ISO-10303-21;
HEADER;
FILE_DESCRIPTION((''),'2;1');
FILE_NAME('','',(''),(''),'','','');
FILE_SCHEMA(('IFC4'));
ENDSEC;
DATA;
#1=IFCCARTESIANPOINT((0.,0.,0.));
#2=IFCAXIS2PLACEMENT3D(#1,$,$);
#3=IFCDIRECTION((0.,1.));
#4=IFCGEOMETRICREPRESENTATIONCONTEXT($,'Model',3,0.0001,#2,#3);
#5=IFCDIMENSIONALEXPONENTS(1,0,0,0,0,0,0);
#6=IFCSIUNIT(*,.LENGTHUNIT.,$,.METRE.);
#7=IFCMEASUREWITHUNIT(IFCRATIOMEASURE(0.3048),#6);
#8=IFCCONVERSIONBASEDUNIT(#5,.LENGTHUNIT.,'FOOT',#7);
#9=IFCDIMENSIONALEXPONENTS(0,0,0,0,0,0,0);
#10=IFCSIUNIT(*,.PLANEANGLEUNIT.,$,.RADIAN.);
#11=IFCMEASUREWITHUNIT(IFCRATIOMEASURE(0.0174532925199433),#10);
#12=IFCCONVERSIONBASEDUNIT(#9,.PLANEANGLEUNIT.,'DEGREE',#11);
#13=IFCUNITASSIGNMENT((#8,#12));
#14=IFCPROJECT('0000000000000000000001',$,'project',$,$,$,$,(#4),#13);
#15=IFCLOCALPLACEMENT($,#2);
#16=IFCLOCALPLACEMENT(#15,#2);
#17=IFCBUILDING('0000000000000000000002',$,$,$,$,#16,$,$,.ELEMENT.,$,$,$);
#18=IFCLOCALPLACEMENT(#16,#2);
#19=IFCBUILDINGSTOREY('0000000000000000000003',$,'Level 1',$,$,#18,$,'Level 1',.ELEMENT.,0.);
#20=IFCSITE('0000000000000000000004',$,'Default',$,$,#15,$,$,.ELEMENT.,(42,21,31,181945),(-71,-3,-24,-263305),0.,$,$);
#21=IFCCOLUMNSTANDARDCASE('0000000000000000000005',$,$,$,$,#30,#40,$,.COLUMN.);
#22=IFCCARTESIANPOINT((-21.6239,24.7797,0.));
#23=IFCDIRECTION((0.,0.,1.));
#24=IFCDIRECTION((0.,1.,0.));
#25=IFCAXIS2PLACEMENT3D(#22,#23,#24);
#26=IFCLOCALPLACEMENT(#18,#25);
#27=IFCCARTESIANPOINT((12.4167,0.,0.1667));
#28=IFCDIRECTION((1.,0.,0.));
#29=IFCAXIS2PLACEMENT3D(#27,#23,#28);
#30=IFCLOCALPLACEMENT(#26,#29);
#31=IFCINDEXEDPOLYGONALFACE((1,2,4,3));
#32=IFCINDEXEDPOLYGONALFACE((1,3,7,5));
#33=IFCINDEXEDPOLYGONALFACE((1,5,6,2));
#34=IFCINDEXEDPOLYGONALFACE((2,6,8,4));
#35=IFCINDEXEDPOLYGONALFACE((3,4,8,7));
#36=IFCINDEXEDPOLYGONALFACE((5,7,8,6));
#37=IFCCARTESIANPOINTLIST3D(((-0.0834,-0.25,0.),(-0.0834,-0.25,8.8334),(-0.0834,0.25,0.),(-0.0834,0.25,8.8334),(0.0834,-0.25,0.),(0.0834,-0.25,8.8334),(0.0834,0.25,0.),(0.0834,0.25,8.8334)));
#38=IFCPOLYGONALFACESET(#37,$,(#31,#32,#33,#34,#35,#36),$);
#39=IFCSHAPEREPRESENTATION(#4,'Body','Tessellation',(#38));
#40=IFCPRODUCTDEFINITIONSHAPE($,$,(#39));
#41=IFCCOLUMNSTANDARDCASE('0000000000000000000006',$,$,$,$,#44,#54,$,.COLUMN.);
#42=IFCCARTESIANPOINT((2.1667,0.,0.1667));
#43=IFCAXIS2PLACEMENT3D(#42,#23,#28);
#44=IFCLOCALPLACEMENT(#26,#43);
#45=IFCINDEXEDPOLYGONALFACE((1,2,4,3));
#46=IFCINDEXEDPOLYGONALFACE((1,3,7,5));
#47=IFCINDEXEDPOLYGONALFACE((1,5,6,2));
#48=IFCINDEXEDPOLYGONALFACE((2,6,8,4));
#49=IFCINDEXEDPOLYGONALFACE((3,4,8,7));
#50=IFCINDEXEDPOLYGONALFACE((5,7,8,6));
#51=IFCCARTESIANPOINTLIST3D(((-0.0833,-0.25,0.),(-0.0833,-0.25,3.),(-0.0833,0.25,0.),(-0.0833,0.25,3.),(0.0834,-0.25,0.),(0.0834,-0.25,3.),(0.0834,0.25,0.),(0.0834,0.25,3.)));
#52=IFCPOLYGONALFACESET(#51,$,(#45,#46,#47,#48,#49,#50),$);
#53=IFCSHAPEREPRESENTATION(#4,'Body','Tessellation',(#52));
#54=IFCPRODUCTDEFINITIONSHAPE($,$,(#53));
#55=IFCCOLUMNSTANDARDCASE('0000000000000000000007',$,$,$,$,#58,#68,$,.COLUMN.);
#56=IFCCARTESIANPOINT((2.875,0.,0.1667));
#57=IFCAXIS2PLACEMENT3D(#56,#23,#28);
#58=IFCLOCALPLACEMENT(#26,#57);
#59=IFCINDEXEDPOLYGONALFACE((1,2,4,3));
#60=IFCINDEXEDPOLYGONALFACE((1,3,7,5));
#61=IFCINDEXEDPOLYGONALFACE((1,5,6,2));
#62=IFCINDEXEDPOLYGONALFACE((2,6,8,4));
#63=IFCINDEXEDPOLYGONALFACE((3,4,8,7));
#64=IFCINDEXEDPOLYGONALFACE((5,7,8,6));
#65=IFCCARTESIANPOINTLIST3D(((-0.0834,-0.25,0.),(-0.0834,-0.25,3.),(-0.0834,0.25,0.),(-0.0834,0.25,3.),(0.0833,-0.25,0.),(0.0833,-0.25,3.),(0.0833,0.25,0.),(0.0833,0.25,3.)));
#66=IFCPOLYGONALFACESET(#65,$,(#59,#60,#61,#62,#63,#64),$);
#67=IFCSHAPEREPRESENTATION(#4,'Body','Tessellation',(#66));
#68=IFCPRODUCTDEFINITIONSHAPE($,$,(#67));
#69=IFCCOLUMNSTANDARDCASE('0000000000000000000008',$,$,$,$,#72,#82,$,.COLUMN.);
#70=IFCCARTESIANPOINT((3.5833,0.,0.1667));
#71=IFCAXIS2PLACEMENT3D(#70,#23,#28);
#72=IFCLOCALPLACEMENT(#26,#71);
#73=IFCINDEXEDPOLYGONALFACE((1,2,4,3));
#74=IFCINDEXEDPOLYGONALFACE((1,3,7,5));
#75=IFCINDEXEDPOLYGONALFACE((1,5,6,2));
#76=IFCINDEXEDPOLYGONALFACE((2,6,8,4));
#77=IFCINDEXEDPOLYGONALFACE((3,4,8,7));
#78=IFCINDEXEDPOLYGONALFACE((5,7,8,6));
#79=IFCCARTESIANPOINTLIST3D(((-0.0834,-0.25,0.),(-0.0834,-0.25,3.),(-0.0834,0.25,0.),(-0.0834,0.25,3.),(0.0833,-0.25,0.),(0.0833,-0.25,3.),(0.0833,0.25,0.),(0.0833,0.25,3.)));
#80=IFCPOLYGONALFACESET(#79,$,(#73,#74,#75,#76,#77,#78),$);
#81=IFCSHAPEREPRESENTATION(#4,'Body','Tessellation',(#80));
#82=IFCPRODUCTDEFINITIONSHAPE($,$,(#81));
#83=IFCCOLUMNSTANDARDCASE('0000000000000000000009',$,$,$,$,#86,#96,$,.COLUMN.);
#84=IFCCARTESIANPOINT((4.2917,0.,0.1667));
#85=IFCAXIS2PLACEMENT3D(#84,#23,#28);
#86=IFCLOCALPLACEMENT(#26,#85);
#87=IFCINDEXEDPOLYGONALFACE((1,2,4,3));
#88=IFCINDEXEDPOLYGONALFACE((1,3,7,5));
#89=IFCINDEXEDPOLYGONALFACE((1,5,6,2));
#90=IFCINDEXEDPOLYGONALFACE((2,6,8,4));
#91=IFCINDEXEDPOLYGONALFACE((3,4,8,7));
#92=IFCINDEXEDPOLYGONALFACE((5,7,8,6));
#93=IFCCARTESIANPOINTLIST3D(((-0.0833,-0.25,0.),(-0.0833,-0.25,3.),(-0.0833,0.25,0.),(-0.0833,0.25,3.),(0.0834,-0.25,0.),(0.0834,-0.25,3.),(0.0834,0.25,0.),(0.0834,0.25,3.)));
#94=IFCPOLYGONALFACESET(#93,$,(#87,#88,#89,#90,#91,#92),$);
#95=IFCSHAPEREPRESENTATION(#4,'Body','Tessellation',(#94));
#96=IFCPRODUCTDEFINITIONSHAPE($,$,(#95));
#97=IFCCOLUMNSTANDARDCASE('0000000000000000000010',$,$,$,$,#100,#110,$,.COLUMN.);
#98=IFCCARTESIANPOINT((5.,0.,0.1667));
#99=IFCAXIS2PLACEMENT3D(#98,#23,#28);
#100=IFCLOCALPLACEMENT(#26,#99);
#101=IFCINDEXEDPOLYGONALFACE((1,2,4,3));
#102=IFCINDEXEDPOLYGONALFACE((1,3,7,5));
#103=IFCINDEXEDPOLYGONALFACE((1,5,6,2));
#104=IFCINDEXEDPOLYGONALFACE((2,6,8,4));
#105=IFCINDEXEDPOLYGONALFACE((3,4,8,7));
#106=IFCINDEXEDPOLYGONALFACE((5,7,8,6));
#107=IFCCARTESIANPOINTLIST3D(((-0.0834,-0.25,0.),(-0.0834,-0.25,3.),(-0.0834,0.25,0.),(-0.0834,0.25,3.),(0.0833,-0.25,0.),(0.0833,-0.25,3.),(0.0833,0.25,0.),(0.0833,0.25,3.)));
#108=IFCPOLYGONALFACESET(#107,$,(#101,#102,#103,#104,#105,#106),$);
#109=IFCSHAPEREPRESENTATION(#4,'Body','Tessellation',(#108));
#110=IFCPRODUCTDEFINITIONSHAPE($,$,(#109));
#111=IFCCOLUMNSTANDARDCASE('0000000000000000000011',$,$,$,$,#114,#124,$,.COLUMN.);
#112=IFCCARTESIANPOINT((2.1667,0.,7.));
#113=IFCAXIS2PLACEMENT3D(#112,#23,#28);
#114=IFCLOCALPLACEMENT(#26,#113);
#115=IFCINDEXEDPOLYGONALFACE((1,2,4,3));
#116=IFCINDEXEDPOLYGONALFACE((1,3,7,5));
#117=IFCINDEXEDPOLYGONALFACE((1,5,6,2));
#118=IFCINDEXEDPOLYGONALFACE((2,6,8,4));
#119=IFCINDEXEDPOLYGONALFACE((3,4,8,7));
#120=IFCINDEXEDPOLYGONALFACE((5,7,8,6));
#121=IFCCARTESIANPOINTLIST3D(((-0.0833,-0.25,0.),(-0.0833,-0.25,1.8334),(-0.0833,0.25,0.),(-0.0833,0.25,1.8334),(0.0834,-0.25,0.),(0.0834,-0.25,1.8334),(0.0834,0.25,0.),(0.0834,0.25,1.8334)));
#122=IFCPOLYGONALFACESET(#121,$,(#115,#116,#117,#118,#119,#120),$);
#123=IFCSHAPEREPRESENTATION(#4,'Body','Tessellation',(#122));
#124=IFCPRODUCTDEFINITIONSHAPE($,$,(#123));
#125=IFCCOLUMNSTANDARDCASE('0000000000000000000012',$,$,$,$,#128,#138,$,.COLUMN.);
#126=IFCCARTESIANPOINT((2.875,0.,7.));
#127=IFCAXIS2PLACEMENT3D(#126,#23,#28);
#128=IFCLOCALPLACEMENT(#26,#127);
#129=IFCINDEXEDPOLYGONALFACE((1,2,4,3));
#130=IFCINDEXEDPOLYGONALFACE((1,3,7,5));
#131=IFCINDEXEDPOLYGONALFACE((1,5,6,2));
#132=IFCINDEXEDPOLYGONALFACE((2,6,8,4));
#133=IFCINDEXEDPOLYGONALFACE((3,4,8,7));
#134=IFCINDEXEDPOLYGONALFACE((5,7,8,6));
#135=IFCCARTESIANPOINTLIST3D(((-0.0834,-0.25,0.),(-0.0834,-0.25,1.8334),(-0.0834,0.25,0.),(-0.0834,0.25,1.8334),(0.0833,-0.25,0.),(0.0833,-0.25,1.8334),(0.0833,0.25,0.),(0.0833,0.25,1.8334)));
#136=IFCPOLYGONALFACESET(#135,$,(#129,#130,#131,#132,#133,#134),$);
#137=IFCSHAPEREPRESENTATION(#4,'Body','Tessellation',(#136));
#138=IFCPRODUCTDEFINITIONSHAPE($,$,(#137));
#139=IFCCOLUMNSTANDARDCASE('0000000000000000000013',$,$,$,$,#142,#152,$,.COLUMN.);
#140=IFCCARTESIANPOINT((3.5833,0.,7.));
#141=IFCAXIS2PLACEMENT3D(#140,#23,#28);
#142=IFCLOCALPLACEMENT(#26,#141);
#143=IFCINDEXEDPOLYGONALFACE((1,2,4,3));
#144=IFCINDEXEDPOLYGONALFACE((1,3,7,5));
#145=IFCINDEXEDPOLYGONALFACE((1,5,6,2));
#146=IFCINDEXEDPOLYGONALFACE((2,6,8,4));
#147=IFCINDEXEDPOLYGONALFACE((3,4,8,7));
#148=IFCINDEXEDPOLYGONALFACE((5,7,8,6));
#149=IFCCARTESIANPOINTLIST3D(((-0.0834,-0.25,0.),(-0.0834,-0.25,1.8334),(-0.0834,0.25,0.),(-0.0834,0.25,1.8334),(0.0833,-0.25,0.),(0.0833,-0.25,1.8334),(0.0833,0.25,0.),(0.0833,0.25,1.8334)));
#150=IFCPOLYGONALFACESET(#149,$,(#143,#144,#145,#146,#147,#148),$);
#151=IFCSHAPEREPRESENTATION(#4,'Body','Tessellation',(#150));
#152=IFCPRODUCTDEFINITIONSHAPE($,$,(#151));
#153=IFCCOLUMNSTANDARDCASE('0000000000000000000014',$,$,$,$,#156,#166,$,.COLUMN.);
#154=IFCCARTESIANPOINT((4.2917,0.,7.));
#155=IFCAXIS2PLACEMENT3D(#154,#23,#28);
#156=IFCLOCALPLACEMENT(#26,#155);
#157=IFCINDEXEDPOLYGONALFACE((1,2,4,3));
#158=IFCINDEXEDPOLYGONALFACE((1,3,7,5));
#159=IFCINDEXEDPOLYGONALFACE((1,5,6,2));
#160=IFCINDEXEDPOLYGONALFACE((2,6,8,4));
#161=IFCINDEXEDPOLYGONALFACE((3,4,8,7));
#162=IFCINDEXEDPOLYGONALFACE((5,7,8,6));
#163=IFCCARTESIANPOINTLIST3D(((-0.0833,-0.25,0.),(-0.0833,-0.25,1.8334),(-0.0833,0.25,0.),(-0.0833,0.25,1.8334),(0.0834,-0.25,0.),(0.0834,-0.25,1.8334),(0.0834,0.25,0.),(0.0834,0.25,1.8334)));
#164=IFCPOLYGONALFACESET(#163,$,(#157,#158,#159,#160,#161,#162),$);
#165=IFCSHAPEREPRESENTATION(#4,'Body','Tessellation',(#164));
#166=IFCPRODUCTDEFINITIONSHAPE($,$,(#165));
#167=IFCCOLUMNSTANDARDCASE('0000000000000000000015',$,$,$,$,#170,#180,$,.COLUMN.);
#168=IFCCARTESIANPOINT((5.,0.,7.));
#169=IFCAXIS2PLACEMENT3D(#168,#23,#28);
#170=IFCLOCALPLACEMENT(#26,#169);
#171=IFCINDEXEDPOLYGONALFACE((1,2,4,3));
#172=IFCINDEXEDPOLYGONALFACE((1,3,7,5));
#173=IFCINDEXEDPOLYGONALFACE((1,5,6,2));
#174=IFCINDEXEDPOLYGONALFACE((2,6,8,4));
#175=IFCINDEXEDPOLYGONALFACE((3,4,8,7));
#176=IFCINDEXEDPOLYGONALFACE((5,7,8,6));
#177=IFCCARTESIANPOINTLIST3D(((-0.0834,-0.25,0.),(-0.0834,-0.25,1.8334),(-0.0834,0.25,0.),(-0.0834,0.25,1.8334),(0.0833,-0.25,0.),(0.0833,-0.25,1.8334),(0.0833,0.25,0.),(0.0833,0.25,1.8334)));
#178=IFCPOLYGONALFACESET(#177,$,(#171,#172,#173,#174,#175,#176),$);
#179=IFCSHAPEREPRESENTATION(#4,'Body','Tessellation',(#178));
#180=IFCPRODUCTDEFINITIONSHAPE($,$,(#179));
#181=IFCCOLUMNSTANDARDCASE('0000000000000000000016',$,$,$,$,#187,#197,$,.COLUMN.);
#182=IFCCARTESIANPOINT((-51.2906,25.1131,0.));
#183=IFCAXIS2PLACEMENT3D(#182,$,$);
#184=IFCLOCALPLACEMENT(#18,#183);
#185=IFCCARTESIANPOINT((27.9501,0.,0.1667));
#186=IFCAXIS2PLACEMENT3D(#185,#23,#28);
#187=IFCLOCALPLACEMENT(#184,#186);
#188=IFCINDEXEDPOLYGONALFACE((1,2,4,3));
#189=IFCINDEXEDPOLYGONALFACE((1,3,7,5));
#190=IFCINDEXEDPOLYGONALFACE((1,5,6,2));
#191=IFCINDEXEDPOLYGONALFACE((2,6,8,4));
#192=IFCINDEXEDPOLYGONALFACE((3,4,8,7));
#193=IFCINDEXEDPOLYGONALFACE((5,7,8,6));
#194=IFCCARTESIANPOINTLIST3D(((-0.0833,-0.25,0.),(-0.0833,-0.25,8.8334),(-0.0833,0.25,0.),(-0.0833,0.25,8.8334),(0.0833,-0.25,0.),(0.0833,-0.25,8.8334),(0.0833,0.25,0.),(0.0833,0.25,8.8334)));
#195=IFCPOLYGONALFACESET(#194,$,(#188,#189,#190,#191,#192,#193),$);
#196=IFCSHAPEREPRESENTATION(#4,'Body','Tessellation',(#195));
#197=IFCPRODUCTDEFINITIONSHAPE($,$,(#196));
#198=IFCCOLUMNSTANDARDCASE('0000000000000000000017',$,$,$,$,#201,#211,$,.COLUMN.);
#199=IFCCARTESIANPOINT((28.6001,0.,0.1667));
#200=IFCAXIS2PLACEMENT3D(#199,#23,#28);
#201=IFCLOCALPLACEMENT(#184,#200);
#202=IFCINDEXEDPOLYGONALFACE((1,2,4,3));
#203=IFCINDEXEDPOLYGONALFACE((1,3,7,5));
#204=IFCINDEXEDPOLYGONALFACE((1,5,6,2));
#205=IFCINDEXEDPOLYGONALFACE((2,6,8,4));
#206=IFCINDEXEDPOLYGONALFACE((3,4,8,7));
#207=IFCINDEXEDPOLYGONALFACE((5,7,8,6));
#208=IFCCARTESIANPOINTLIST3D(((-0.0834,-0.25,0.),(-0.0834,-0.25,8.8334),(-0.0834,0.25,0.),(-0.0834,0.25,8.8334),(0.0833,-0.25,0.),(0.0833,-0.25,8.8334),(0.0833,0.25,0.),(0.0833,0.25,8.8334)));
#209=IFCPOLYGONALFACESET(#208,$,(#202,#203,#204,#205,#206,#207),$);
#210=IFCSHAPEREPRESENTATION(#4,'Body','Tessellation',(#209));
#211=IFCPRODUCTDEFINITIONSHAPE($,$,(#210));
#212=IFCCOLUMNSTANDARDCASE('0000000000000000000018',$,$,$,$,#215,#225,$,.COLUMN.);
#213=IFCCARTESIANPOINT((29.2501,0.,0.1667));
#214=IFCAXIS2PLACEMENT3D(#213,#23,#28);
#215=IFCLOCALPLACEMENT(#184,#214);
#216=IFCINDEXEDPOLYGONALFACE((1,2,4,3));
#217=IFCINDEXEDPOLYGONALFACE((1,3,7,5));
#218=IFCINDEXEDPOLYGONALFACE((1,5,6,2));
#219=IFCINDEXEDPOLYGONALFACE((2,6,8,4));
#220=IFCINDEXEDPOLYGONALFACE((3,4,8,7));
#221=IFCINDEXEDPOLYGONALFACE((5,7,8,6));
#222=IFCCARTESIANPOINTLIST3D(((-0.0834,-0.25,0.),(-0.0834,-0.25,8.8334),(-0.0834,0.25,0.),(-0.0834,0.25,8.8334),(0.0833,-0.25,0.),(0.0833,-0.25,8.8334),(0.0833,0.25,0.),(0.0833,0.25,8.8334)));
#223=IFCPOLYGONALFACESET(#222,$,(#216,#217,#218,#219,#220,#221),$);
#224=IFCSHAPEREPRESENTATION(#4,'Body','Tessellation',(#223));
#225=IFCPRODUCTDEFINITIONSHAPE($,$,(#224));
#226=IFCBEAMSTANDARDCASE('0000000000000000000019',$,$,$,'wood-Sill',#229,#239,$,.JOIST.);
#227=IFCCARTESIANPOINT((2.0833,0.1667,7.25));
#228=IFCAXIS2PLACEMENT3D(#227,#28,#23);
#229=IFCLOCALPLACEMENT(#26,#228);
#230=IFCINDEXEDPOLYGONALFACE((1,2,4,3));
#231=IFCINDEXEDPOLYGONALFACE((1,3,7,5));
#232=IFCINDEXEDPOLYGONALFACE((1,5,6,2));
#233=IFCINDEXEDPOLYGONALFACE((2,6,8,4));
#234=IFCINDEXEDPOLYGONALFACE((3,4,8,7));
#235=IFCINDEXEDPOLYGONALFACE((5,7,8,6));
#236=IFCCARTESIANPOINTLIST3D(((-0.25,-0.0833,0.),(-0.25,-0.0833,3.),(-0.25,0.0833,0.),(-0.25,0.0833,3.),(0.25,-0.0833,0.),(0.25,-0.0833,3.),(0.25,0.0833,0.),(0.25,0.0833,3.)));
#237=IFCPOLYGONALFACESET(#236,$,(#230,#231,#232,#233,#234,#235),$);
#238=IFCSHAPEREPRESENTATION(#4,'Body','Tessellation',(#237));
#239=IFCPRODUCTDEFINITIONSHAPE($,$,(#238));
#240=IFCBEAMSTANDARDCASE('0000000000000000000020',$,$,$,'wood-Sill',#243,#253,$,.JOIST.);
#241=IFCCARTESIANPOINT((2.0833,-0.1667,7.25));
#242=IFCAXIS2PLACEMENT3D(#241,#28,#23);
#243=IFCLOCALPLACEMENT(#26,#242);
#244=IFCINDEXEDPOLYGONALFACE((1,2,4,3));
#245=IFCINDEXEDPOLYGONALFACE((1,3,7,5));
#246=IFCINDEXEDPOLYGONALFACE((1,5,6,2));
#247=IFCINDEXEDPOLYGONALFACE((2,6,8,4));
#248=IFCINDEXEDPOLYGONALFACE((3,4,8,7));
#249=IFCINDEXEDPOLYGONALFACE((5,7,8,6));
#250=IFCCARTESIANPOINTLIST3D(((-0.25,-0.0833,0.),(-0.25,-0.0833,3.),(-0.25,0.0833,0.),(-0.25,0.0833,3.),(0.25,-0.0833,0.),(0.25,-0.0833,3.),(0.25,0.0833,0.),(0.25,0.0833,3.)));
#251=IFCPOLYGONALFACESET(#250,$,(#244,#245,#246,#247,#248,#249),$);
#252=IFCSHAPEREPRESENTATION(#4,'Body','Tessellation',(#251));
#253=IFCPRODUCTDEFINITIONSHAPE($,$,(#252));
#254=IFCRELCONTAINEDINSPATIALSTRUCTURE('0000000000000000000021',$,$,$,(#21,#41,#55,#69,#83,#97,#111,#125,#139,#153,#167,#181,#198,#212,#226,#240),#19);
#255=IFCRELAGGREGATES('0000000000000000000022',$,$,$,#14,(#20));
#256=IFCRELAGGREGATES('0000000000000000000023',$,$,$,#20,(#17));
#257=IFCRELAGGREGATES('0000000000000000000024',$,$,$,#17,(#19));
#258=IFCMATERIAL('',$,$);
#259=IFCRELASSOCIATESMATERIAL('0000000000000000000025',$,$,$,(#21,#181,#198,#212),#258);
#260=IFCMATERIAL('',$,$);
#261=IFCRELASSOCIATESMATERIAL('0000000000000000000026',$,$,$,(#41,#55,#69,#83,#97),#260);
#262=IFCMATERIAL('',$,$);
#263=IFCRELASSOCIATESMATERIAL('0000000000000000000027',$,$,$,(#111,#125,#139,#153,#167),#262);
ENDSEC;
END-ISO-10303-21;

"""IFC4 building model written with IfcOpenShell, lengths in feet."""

from ifc_helpers import new_model, entity, si_unit, converted_unit, direction, frame, origin, origin_with_axes, place, context, project, spatial, rectangle, extrude, material, element, save


model = new_model("IFC4")

# Units and contexts
model_context = context("Model", 3, precision=0.0001, world=origin(), true_north=direction((0.0, 1.0)))
ifc_project = project(units=[converted_unit("LENGTHUNIT", "FOOT", entity("IfcRatioMeasure", 0.3048), si_unit("LENGTHUNIT", "METRE"), dimensions=[1, 0, 0, 0, 0, 0, 0]), converted_unit("PLANEANGLEUNIT", "DEGREE", entity("IfcRatioMeasure", 0.0174532925199433), si_unit("PLANEANGLEUNIT", "RADIAN"), dimensions=[0, 0, 0, 0, 0, 0, 0])], contexts=[model_context])

# Site, building, storey
site_placement = place(None, origin())
site = spatial("IfcSite", under=ifc_project, at=site_placement, Name="Default", CompositionType="ELEMENT", RefLatitude=(42, 21, 31, 181945), RefLongitude=(-71, -3, -24, -263305), RefElevation=0.0)
building_placement = place(site_placement, origin())
building = spatial("IfcBuilding", under=site, at=building_placement, CompositionType="ELEMENT")
storey_placement = place(building_placement, origin())
storey = spatial("IfcBuildingStorey", under=building, at=storey_placement, Name="Level 1", LongName="Level 1", CompositionType="ELEMENT", Elevation=0.0)

# Columns
placement_1 = place(storey_placement, frame((-21.6239, 24.7797, 0.0), z_axis=(0.0, 0.0, 1.0), x_axis=(0.0, 1.0, 0.0)))
ifc_material_1 = material(Name="")
for number, where, z_axis, x_axis in (
    (1, (12.4167, 0.0, 0.1667), (0.0, 0.0, 1.0), (1.0, 0.0, 0.0)),
):
    element("IfcColumnStandardCase", number, at=place(placement_1, frame(where, z_axis=z_axis, x_axis=x_axis)), inside=storey, material=ifc_material_1, PredefinedType="COLUMN", context=model_context, shape_type="SweptSolid", body=[
        extrude(rectangle(XDim=0.1667, YDim=0.5), origin(), (0.0, 0.0, 1.0), 8.8334),
    ])
ifc_material_2 = material(Name="")
for number, where, z_axis, x_axis in (
    (2, (2.1667, 0.0, 0.1667), (0.0, 0.0, 1.0), (1.0, 0.0, 0.0)),
    (3, (2.875, 0.0, 0.1667), (0.0, 0.0, 1.0), (1.0, 0.0, 0.0)),
    (4, (3.5833, 0.0, 0.1667), (0.0, 0.0, 1.0), (1.0, 0.0, 0.0)),
    (5, (4.2917, 0.0, 0.1667), (0.0, 0.0, 1.0), (1.0, 0.0, 0.0)),
    (6, (5.0, 0.0, 0.1667), (0.0, 0.0, 1.0), (1.0, 0.0, 0.0)),
):
    element("IfcColumnStandardCase", number, at=place(placement_1, frame(where, z_axis=z_axis, x_axis=x_axis)), inside=storey, material=ifc_material_2, PredefinedType="COLUMN", context=model_context, shape_type="SweptSolid", body=[
        extrude(rectangle(XDim=0.1667, YDim=0.5), origin(), (0.0, 0.0, 1.0), 3.0),
    ])
ifc_material_3 = material(Name="")
for number, where, z_axis, x_axis in (
    (7, (2.1667, 0.0, 7.0), (0.0, 0.0, 1.0), (1.0, 0.0, 0.0)),
    (8, (2.875, 0.0, 7.0), (0.0, 0.0, 1.0), (1.0, 0.0, 0.0)),
    (9, (3.5833, 0.0, 7.0), (0.0, 0.0, 1.0), (1.0, 0.0, 0.0)),
    (10, (4.2917, 0.0, 7.0), (0.0, 0.0, 1.0), (1.0, 0.0, 0.0)),
    (11, (5.0, 0.0, 7.0), (0.0, 0.0, 1.0), (1.0, 0.0, 0.0)),
):
    element("IfcColumnStandardCase", number, at=place(placement_1, frame(where, z_axis=z_axis, x_axis=x_axis)), inside=storey, material=ifc_material_3, PredefinedType="COLUMN", context=model_context, shape_type="SweptSolid", body=[
        extrude(rectangle(XDim=0.1667, YDim=0.5), origin(), (0.0, 0.0, 1.0), 1.8334),
    ])
placement_2 = place(storey_placement, frame((-51.2906, 25.1131, 0.0)))
for number, where, z_axis, x_axis in (
    (12, (27.9501, 0.0, 0.1667), (0.0, 0.0, 1.0), (1.0, 0.0, 0.0)),
    (13, (28.6001, 0.0, 0.1667), (0.0, 0.0, 1.0), (1.0, 0.0, 0.0)),
    (14, (29.2501, 0.0, 0.1667), (0.0, 0.0, 1.0), (1.0, 0.0, 0.0)),
):
    element("IfcColumnStandardCase", number, at=place(placement_2, frame(where, z_axis=z_axis, x_axis=x_axis)), inside=storey, material=ifc_material_1, PredefinedType="COLUMN", context=model_context, shape_type="SweptSolid", body=[
        extrude(rectangle(XDim=0.1667, YDim=0.5), origin(), (0.0, 0.0, 1.0), 8.8334),
    ])

# Beams
for number, where, z_axis, x_axis in (
    (15, (2.0833, 0.1667, 7.25), (1.0, 0.0, 0.0), (0.0, 0.0, 1.0)),
    (16, (2.0833, -0.1667, 7.25), (1.0, 0.0, 0.0), (0.0, 0.0, 1.0)),
):
    element("IfcBeamStandardCase", number, at=place(placement_1, frame(where, z_axis=z_axis, x_axis=x_axis)), inside=storey, ObjectType="wood-Sill", PredefinedType="JOIST", context=model_context, shape_type="SweptSolid", body=[
        extrude(rectangle(XDim=0.5, YDim=0.1667), origin_with_axes(), (0.0, 0.0, 1.0), 3.0),
    ])

save(model, "model.ifc")
